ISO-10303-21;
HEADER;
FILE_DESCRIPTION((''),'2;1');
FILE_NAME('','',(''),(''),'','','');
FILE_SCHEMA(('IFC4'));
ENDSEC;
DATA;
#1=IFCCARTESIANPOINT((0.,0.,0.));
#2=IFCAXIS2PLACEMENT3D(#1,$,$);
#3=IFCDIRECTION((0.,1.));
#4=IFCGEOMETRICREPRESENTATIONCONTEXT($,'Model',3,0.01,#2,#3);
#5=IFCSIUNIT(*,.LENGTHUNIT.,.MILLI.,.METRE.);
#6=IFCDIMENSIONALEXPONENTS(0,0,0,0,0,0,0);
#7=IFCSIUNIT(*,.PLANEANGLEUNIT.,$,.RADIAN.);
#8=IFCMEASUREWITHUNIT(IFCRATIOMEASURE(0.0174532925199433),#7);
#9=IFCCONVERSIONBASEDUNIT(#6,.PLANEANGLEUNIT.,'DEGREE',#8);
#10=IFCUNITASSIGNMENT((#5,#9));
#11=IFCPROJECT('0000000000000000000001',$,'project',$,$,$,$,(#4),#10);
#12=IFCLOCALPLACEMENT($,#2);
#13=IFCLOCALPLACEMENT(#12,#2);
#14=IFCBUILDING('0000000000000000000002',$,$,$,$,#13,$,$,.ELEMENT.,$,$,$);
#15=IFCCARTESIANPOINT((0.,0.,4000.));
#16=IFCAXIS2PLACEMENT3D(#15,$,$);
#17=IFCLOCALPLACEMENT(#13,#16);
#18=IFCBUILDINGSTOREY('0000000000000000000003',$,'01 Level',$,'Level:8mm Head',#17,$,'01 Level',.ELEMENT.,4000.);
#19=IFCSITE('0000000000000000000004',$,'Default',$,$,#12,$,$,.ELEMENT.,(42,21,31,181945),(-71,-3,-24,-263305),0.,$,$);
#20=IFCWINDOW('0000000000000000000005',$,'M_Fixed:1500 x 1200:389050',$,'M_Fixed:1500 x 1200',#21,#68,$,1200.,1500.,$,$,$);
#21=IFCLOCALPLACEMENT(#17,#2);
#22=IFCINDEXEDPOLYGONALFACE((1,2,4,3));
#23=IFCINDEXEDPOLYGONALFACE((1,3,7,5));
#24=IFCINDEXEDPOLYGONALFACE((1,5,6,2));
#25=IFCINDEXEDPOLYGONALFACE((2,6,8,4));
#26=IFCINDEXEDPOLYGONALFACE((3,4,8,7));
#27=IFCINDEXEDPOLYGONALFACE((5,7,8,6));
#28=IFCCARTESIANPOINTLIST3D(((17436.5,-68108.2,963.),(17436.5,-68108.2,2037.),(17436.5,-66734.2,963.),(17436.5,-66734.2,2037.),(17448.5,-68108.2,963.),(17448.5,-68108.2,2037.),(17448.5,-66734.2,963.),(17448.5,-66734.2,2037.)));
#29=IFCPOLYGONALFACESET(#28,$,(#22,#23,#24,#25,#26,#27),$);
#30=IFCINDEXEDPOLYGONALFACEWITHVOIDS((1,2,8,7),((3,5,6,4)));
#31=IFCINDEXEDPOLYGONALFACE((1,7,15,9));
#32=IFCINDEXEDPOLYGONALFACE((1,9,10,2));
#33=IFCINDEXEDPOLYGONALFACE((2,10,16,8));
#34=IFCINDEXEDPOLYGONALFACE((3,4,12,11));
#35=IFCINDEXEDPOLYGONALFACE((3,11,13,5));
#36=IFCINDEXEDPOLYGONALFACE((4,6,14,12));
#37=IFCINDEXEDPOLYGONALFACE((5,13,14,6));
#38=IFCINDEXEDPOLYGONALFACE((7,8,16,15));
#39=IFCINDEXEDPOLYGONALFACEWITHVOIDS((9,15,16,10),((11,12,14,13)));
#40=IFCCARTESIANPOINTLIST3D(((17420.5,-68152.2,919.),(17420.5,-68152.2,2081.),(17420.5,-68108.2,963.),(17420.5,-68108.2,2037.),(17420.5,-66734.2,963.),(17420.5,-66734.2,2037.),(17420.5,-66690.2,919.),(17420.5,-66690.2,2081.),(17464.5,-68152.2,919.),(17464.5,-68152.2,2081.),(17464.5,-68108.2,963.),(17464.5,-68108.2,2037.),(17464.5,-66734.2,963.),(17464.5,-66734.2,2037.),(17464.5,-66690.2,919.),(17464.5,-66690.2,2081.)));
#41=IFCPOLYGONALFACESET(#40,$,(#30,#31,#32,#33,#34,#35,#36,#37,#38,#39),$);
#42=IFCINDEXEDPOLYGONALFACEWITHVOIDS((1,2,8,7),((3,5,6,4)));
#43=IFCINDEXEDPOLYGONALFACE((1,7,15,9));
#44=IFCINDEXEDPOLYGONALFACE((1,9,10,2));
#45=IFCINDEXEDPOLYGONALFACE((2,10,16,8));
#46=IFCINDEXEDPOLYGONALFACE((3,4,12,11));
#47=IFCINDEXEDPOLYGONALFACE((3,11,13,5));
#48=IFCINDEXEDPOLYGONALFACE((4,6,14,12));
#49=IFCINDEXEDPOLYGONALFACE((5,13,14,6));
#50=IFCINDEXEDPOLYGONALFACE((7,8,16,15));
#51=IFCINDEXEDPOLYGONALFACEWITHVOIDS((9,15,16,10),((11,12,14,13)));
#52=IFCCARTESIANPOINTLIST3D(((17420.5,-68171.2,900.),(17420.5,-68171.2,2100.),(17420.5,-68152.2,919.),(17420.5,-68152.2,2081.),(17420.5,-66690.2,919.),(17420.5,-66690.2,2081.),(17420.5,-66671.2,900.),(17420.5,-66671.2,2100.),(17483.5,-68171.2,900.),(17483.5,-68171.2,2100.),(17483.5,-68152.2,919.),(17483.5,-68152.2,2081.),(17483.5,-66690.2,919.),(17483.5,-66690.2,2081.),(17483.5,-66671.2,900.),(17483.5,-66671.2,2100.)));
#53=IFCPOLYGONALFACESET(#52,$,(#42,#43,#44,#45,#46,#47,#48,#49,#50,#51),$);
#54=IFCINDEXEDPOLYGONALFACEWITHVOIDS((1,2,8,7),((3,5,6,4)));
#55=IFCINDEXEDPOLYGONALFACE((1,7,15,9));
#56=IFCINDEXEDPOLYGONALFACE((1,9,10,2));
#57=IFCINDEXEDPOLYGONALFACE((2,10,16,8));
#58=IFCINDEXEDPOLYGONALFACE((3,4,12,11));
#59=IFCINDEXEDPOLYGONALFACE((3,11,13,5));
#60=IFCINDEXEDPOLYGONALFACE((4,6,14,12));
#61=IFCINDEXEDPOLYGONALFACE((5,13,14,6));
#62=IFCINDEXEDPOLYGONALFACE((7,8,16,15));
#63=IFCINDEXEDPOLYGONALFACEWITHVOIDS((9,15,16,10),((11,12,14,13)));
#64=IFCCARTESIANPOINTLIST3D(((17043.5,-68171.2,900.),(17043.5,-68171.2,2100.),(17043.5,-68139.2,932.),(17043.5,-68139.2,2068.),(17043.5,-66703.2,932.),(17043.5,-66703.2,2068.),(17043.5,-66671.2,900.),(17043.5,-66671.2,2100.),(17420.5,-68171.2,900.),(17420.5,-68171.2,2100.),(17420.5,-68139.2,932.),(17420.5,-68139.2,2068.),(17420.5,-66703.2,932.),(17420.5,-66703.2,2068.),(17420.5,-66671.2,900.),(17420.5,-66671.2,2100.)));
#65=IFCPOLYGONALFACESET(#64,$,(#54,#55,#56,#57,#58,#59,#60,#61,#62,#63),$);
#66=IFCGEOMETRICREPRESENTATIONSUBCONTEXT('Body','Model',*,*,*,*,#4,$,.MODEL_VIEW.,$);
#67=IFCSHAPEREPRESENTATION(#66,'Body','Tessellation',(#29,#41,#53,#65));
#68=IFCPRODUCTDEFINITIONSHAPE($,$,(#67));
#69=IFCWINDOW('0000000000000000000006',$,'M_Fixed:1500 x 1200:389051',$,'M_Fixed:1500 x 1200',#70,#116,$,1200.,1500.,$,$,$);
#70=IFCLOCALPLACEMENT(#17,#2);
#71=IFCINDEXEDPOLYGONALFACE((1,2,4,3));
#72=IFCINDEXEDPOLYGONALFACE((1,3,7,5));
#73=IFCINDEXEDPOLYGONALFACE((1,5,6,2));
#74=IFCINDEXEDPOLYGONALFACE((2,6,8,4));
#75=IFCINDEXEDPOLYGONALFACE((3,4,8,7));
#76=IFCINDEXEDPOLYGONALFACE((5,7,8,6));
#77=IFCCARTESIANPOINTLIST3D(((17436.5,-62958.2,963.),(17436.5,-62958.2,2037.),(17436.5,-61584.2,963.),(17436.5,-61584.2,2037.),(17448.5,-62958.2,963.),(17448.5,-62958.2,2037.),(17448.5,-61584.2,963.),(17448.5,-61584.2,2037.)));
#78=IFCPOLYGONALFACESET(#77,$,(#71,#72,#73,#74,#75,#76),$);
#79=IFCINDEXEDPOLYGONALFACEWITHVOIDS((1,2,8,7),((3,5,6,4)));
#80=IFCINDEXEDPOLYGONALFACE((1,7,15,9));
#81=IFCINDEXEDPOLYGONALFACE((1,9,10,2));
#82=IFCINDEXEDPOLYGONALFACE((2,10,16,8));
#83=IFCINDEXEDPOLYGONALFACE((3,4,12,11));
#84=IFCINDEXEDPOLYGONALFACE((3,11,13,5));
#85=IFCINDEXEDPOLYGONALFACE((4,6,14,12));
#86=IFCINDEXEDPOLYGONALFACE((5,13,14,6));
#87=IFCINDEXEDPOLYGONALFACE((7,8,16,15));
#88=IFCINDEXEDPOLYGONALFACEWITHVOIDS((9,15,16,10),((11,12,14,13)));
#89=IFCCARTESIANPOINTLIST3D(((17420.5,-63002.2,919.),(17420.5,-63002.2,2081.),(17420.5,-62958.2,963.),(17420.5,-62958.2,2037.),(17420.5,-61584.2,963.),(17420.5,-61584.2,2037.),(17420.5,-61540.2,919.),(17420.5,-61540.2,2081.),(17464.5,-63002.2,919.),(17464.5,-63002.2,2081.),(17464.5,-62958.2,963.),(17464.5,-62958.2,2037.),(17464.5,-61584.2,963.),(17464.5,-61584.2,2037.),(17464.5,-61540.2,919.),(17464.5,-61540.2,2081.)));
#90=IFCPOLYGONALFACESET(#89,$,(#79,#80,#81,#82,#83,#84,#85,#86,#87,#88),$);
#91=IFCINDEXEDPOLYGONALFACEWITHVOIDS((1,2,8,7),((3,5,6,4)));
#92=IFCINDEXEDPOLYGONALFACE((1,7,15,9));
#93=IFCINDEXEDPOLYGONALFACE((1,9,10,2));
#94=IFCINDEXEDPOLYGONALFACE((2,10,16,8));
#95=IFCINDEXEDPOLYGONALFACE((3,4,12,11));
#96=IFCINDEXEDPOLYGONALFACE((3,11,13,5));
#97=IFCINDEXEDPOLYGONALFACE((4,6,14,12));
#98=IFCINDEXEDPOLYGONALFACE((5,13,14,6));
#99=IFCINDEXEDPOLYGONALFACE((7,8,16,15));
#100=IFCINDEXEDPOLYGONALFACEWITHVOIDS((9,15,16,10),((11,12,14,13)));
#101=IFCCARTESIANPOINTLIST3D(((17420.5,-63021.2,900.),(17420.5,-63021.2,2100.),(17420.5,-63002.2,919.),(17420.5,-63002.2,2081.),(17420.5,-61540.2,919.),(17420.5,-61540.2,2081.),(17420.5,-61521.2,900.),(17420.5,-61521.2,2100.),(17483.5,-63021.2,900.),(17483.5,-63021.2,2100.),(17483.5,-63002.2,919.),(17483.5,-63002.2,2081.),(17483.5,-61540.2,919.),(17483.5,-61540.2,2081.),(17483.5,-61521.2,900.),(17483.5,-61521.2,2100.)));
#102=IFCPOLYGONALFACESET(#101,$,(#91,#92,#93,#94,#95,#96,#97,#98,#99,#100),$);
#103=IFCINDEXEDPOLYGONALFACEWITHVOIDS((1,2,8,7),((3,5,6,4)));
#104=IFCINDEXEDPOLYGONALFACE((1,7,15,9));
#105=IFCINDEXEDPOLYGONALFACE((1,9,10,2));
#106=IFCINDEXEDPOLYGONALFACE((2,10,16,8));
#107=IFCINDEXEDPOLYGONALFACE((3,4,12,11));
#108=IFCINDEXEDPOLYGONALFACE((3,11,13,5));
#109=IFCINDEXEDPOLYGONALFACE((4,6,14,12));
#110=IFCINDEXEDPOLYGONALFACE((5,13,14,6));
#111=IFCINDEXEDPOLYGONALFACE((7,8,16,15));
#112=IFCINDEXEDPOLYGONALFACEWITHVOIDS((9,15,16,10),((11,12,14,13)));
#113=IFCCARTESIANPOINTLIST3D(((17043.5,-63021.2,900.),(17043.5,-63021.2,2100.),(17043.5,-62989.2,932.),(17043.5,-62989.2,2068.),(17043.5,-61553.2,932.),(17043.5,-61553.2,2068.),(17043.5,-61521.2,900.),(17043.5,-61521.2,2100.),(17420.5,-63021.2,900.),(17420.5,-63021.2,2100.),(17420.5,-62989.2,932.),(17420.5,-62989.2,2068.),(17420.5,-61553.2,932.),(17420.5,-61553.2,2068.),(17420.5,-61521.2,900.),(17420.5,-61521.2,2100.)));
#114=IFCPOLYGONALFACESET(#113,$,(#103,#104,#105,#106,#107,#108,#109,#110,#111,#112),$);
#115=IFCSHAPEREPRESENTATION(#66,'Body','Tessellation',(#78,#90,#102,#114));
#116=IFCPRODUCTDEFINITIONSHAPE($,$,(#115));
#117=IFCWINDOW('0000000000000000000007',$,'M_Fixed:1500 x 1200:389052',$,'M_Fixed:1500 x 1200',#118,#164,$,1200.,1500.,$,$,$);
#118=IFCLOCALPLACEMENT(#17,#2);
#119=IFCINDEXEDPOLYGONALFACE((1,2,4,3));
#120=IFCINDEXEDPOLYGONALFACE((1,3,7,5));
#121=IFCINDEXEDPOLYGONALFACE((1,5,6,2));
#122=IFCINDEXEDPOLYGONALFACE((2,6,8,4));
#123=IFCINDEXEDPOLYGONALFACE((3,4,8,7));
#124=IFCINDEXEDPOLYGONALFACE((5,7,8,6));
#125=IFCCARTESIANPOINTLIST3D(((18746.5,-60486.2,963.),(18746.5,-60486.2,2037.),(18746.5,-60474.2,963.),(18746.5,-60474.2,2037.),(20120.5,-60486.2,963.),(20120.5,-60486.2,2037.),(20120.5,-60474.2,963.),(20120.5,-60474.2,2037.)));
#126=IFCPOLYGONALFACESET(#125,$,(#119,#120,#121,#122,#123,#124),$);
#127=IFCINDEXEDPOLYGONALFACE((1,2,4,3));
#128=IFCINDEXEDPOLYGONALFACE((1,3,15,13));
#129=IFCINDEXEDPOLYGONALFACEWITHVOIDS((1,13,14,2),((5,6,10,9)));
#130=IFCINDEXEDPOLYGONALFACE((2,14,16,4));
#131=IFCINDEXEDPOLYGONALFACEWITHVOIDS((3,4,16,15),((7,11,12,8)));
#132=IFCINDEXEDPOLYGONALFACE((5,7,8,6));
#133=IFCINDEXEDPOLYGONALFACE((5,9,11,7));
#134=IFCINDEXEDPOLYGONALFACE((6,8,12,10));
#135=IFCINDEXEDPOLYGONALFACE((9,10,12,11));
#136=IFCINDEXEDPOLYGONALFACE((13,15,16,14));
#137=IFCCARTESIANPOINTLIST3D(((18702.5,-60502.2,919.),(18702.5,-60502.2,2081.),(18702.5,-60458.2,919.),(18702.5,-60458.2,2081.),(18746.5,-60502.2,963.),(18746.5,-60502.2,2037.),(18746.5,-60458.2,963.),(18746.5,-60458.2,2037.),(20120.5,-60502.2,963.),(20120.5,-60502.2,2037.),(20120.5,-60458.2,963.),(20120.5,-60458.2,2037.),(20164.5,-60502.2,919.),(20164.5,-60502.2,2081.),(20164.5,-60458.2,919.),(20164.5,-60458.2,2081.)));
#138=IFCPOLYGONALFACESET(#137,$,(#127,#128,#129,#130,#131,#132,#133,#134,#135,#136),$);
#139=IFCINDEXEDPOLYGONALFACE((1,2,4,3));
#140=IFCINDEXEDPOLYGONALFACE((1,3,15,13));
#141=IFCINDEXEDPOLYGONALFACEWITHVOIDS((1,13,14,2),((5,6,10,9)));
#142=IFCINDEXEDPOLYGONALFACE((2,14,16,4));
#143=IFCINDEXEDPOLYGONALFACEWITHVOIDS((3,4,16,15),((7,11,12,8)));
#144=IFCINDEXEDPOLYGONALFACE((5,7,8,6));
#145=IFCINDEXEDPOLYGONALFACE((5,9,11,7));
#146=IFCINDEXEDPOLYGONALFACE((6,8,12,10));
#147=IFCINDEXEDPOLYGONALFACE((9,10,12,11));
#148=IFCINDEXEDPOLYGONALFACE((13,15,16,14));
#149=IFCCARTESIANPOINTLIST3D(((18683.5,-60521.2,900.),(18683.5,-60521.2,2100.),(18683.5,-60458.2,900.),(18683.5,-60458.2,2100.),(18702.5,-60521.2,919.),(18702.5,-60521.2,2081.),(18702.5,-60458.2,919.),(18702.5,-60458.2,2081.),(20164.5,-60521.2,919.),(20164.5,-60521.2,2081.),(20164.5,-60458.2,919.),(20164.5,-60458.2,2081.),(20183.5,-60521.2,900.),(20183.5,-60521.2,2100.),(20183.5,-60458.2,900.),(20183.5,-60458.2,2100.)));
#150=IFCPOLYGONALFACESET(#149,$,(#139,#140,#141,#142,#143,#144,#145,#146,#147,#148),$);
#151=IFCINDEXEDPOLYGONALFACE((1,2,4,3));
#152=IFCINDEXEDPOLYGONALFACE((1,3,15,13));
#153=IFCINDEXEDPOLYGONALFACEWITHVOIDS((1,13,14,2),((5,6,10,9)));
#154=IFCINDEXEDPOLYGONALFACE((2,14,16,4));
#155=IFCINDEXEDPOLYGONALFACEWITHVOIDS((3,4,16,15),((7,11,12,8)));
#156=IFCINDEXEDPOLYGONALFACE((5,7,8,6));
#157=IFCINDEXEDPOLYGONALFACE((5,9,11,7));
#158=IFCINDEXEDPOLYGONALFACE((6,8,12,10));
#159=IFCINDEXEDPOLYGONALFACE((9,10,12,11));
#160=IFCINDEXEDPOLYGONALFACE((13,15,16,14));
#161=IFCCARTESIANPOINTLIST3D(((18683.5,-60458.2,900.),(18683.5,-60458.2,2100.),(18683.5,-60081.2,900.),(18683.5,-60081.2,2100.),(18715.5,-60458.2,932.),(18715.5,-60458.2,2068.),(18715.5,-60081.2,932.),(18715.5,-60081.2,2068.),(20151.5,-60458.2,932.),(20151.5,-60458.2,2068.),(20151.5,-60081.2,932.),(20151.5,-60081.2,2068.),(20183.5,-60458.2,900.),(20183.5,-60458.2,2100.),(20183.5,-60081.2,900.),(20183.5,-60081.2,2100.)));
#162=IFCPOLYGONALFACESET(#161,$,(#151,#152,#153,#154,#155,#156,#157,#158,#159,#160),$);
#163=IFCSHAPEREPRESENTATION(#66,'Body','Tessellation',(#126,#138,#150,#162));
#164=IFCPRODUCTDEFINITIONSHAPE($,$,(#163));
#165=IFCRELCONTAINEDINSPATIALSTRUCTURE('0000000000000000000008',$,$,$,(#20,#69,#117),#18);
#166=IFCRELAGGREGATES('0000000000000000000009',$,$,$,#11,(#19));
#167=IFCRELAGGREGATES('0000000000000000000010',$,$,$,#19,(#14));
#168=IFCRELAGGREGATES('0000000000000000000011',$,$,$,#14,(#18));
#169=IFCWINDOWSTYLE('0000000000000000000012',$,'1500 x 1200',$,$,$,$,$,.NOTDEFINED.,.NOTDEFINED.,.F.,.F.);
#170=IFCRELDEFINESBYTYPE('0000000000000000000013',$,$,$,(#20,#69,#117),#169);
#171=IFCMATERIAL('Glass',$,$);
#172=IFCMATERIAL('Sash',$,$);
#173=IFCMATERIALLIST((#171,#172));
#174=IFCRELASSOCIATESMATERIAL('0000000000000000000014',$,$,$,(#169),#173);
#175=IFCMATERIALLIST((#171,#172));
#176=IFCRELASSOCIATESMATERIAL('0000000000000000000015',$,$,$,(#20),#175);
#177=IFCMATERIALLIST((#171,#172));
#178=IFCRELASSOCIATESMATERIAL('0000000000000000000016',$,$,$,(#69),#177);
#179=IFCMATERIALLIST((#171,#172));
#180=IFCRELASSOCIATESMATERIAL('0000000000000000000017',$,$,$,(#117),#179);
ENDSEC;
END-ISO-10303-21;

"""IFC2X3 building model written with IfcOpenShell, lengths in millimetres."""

from ifc_helpers import new_model, entity, si_unit, converted_unit, direction, frame, origin, origin_2d_with_axis, place, context, subcontext, project, spatial, polyline, rectangle, outline, extrude, source, transform, mapped, material, material_list, type_object, type_shapes, element, save


model = new_model("IFC2X3")

# Units and contexts
model_context = context("Model", 3, precision=0.01, world=origin(), true_north=direction((0.0, 1.0)))
body_context = subcontext(model_context, "Body", "Model", "MODEL_VIEW")
ifc_project = project(units=[si_unit("LENGTHUNIT", "METRE", prefix="MILLI"), converted_unit("PLANEANGLEUNIT", "DEGREE", entity("IfcRatioMeasure", 0.0174532925199433), si_unit("PLANEANGLEUNIT", "RADIAN"), dimensions=[0, 0, 0, 0, 0, 0, 0])], contexts=[model_context])

# Site, building, storey
site_placement = place(None, origin())
site = spatial("IfcSite", under=ifc_project, at=site_placement, Name="Default", CompositionType="ELEMENT", RefLatitude=(42, 21, 31, 181945), RefLongitude=(-71, -3, -24, -263305), RefElevation=0.0)
building_placement = place(site_placement, origin())
building = spatial("IfcBuilding", under=site, at=building_placement, CompositionType="ELEMENT")
storey_placement = place(building_placement, frame((0.0, 0.0, 4000.0)))
storey = spatial("IfcBuildingStorey", under=building, at=storey_placement, Name="01 Level", ObjectType="Level:8mm Head", LongName="01 Level", CompositionType="ELEMENT", Elevation=4000.0)

# Windows
ifc_material_1 = material(Name="Glass")
ifc_material_2 = material(Name="Sash")
ifc_material_list_1 = material_list([ifc_material_1, ifc_material_2])
ifc_material_list_2 = material_list([ifc_material_1, ifc_material_2])
window_style_1 = type_object("IfcWindowStyle", Name="1500 x 1200", ConstructionType="NOTDEFINED", OperationType="NOTDEFINED", ParameterTakesPrecedence=False, Sizeable=False, material=ifc_material_list_2)
shared_shape_1 = source(origin(), body_context, "Body", "SweptSolid", [
    extrude(rectangle(XDim=1374.0, YDim=12.0, at=origin_2d_with_axis()), frame((750.0, 425.0, 63.0), z_axis=(0.0, 0.0, 1.0), x_axis=(-1.0, 0.0, 0.0)), (0.0, 0.0, 1.0), 1074.0),
    extrude(outline(polyline([(-731.0, -581.0), (731.0, -581.0), (731.0, 581.0), (-731.0, 581.0), (-731.0, -581.0)]), holes=[polyline([(-687.0, -537.0), (-687.0, 537.0), (687.0, 537.0), (687.0, -537.0), (-687.0, -537.0)])]), frame((750.0, 447.0, 600.0), z_axis=(0.0, -1.0, 0.0), x_axis=(-1.0, 0.0, 0.0)), (0.0, 0.0, 1.0), 44.0),
    extrude(outline(polyline([(-750.0, -600.0), (750.0, -600.0), (750.0, 600.0), (-750.0, 600.0), (-750.0, -600.0)]), holes=[polyline([(-731.0, -581.0), (-731.0, 581.0), (731.0, 581.0), (731.0, -581.0), (-731.0, -581.0)])]), frame((750.0, 466.0, 600.0), z_axis=(0.0, -1.0, 0.0), x_axis=(-1.0, 0.0, 0.0)), (0.0, 0.0, 1.0), 63.0),
    extrude(outline(polyline([(-750.0, -600.0), (750.0, -600.0), (750.0, 600.0), (-750.0, 600.0), (-750.0, -600.0)]), holes=[polyline([(-718.0, -568.0), (-718.0, 568.0), (718.0, 568.0), (718.0, -568.0), (-718.0, -568.0)])]), frame((750.0, 403.0, 600.0), z_axis=(0.0, -1.0, 0.0), x_axis=(-1.0, 0.0, 0.0)), (0.0, 0.0, 1.0), 377.0),
])
type_shapes(window_style_1, [shared_shape_1])
window_1_placement = place(storey_placement, frame((17017.5, -66671.2, 900.0), z_axis=(0.0, 0.0, 1.0), x_axis=(0.0, -1.0, 0.0)))
element("IfcWindow", 1, at=window_1_placement, inside=storey, type_object=window_style_1, material=ifc_material_list_1, Name="M_Fixed:1500 x 1200:389050", ObjectType="M_Fixed:1500 x 1200", OverallHeight=1200.0, OverallWidth=1500.0, context=body_context, shape_type="MappedRepresentation", body=[
    mapped(shared_shape_1, transform((0.0, 0.0, 0.0), scale=1.0)),
])
ifc_material_list_3 = material_list([ifc_material_1, ifc_material_2])
window_2_placement = place(storey_placement, frame((17017.5, -61521.2, 900.0), z_axis=(0.0, 0.0, 1.0), x_axis=(0.0, -1.0, 0.0)))
element("IfcWindow", 2, at=window_2_placement, inside=storey, type_object=window_style_1, material=ifc_material_list_3, Name="M_Fixed:1500 x 1200:389051", ObjectType="M_Fixed:1500 x 1200", OverallHeight=1200.0, OverallWidth=1500.0, context=body_context, shape_type="MappedRepresentation", body=[
    mapped(shared_shape_1, transform((0.0, 0.0, 0.0), scale=1.0)),
])
ifc_material_list_4 = material_list([ifc_material_1, ifc_material_2])
window_3_placement = place(storey_placement, frame((20183.5, -60055.2, 900.0), z_axis=(0.0, 0.0, 1.0), x_axis=(-1.0, 0.0, 0.0)))
element("IfcWindow", 3, at=window_3_placement, inside=storey, type_object=window_style_1, material=ifc_material_list_4, Name="M_Fixed:1500 x 1200:389052", ObjectType="M_Fixed:1500 x 1200", OverallHeight=1200.0, OverallWidth=1500.0, context=body_context, shape_type="MappedRepresentation", body=[
    mapped(shared_shape_1, transform((0.0, 0.0, 0.0), scale=1.0)),
])

save(model, "model.ifc")
